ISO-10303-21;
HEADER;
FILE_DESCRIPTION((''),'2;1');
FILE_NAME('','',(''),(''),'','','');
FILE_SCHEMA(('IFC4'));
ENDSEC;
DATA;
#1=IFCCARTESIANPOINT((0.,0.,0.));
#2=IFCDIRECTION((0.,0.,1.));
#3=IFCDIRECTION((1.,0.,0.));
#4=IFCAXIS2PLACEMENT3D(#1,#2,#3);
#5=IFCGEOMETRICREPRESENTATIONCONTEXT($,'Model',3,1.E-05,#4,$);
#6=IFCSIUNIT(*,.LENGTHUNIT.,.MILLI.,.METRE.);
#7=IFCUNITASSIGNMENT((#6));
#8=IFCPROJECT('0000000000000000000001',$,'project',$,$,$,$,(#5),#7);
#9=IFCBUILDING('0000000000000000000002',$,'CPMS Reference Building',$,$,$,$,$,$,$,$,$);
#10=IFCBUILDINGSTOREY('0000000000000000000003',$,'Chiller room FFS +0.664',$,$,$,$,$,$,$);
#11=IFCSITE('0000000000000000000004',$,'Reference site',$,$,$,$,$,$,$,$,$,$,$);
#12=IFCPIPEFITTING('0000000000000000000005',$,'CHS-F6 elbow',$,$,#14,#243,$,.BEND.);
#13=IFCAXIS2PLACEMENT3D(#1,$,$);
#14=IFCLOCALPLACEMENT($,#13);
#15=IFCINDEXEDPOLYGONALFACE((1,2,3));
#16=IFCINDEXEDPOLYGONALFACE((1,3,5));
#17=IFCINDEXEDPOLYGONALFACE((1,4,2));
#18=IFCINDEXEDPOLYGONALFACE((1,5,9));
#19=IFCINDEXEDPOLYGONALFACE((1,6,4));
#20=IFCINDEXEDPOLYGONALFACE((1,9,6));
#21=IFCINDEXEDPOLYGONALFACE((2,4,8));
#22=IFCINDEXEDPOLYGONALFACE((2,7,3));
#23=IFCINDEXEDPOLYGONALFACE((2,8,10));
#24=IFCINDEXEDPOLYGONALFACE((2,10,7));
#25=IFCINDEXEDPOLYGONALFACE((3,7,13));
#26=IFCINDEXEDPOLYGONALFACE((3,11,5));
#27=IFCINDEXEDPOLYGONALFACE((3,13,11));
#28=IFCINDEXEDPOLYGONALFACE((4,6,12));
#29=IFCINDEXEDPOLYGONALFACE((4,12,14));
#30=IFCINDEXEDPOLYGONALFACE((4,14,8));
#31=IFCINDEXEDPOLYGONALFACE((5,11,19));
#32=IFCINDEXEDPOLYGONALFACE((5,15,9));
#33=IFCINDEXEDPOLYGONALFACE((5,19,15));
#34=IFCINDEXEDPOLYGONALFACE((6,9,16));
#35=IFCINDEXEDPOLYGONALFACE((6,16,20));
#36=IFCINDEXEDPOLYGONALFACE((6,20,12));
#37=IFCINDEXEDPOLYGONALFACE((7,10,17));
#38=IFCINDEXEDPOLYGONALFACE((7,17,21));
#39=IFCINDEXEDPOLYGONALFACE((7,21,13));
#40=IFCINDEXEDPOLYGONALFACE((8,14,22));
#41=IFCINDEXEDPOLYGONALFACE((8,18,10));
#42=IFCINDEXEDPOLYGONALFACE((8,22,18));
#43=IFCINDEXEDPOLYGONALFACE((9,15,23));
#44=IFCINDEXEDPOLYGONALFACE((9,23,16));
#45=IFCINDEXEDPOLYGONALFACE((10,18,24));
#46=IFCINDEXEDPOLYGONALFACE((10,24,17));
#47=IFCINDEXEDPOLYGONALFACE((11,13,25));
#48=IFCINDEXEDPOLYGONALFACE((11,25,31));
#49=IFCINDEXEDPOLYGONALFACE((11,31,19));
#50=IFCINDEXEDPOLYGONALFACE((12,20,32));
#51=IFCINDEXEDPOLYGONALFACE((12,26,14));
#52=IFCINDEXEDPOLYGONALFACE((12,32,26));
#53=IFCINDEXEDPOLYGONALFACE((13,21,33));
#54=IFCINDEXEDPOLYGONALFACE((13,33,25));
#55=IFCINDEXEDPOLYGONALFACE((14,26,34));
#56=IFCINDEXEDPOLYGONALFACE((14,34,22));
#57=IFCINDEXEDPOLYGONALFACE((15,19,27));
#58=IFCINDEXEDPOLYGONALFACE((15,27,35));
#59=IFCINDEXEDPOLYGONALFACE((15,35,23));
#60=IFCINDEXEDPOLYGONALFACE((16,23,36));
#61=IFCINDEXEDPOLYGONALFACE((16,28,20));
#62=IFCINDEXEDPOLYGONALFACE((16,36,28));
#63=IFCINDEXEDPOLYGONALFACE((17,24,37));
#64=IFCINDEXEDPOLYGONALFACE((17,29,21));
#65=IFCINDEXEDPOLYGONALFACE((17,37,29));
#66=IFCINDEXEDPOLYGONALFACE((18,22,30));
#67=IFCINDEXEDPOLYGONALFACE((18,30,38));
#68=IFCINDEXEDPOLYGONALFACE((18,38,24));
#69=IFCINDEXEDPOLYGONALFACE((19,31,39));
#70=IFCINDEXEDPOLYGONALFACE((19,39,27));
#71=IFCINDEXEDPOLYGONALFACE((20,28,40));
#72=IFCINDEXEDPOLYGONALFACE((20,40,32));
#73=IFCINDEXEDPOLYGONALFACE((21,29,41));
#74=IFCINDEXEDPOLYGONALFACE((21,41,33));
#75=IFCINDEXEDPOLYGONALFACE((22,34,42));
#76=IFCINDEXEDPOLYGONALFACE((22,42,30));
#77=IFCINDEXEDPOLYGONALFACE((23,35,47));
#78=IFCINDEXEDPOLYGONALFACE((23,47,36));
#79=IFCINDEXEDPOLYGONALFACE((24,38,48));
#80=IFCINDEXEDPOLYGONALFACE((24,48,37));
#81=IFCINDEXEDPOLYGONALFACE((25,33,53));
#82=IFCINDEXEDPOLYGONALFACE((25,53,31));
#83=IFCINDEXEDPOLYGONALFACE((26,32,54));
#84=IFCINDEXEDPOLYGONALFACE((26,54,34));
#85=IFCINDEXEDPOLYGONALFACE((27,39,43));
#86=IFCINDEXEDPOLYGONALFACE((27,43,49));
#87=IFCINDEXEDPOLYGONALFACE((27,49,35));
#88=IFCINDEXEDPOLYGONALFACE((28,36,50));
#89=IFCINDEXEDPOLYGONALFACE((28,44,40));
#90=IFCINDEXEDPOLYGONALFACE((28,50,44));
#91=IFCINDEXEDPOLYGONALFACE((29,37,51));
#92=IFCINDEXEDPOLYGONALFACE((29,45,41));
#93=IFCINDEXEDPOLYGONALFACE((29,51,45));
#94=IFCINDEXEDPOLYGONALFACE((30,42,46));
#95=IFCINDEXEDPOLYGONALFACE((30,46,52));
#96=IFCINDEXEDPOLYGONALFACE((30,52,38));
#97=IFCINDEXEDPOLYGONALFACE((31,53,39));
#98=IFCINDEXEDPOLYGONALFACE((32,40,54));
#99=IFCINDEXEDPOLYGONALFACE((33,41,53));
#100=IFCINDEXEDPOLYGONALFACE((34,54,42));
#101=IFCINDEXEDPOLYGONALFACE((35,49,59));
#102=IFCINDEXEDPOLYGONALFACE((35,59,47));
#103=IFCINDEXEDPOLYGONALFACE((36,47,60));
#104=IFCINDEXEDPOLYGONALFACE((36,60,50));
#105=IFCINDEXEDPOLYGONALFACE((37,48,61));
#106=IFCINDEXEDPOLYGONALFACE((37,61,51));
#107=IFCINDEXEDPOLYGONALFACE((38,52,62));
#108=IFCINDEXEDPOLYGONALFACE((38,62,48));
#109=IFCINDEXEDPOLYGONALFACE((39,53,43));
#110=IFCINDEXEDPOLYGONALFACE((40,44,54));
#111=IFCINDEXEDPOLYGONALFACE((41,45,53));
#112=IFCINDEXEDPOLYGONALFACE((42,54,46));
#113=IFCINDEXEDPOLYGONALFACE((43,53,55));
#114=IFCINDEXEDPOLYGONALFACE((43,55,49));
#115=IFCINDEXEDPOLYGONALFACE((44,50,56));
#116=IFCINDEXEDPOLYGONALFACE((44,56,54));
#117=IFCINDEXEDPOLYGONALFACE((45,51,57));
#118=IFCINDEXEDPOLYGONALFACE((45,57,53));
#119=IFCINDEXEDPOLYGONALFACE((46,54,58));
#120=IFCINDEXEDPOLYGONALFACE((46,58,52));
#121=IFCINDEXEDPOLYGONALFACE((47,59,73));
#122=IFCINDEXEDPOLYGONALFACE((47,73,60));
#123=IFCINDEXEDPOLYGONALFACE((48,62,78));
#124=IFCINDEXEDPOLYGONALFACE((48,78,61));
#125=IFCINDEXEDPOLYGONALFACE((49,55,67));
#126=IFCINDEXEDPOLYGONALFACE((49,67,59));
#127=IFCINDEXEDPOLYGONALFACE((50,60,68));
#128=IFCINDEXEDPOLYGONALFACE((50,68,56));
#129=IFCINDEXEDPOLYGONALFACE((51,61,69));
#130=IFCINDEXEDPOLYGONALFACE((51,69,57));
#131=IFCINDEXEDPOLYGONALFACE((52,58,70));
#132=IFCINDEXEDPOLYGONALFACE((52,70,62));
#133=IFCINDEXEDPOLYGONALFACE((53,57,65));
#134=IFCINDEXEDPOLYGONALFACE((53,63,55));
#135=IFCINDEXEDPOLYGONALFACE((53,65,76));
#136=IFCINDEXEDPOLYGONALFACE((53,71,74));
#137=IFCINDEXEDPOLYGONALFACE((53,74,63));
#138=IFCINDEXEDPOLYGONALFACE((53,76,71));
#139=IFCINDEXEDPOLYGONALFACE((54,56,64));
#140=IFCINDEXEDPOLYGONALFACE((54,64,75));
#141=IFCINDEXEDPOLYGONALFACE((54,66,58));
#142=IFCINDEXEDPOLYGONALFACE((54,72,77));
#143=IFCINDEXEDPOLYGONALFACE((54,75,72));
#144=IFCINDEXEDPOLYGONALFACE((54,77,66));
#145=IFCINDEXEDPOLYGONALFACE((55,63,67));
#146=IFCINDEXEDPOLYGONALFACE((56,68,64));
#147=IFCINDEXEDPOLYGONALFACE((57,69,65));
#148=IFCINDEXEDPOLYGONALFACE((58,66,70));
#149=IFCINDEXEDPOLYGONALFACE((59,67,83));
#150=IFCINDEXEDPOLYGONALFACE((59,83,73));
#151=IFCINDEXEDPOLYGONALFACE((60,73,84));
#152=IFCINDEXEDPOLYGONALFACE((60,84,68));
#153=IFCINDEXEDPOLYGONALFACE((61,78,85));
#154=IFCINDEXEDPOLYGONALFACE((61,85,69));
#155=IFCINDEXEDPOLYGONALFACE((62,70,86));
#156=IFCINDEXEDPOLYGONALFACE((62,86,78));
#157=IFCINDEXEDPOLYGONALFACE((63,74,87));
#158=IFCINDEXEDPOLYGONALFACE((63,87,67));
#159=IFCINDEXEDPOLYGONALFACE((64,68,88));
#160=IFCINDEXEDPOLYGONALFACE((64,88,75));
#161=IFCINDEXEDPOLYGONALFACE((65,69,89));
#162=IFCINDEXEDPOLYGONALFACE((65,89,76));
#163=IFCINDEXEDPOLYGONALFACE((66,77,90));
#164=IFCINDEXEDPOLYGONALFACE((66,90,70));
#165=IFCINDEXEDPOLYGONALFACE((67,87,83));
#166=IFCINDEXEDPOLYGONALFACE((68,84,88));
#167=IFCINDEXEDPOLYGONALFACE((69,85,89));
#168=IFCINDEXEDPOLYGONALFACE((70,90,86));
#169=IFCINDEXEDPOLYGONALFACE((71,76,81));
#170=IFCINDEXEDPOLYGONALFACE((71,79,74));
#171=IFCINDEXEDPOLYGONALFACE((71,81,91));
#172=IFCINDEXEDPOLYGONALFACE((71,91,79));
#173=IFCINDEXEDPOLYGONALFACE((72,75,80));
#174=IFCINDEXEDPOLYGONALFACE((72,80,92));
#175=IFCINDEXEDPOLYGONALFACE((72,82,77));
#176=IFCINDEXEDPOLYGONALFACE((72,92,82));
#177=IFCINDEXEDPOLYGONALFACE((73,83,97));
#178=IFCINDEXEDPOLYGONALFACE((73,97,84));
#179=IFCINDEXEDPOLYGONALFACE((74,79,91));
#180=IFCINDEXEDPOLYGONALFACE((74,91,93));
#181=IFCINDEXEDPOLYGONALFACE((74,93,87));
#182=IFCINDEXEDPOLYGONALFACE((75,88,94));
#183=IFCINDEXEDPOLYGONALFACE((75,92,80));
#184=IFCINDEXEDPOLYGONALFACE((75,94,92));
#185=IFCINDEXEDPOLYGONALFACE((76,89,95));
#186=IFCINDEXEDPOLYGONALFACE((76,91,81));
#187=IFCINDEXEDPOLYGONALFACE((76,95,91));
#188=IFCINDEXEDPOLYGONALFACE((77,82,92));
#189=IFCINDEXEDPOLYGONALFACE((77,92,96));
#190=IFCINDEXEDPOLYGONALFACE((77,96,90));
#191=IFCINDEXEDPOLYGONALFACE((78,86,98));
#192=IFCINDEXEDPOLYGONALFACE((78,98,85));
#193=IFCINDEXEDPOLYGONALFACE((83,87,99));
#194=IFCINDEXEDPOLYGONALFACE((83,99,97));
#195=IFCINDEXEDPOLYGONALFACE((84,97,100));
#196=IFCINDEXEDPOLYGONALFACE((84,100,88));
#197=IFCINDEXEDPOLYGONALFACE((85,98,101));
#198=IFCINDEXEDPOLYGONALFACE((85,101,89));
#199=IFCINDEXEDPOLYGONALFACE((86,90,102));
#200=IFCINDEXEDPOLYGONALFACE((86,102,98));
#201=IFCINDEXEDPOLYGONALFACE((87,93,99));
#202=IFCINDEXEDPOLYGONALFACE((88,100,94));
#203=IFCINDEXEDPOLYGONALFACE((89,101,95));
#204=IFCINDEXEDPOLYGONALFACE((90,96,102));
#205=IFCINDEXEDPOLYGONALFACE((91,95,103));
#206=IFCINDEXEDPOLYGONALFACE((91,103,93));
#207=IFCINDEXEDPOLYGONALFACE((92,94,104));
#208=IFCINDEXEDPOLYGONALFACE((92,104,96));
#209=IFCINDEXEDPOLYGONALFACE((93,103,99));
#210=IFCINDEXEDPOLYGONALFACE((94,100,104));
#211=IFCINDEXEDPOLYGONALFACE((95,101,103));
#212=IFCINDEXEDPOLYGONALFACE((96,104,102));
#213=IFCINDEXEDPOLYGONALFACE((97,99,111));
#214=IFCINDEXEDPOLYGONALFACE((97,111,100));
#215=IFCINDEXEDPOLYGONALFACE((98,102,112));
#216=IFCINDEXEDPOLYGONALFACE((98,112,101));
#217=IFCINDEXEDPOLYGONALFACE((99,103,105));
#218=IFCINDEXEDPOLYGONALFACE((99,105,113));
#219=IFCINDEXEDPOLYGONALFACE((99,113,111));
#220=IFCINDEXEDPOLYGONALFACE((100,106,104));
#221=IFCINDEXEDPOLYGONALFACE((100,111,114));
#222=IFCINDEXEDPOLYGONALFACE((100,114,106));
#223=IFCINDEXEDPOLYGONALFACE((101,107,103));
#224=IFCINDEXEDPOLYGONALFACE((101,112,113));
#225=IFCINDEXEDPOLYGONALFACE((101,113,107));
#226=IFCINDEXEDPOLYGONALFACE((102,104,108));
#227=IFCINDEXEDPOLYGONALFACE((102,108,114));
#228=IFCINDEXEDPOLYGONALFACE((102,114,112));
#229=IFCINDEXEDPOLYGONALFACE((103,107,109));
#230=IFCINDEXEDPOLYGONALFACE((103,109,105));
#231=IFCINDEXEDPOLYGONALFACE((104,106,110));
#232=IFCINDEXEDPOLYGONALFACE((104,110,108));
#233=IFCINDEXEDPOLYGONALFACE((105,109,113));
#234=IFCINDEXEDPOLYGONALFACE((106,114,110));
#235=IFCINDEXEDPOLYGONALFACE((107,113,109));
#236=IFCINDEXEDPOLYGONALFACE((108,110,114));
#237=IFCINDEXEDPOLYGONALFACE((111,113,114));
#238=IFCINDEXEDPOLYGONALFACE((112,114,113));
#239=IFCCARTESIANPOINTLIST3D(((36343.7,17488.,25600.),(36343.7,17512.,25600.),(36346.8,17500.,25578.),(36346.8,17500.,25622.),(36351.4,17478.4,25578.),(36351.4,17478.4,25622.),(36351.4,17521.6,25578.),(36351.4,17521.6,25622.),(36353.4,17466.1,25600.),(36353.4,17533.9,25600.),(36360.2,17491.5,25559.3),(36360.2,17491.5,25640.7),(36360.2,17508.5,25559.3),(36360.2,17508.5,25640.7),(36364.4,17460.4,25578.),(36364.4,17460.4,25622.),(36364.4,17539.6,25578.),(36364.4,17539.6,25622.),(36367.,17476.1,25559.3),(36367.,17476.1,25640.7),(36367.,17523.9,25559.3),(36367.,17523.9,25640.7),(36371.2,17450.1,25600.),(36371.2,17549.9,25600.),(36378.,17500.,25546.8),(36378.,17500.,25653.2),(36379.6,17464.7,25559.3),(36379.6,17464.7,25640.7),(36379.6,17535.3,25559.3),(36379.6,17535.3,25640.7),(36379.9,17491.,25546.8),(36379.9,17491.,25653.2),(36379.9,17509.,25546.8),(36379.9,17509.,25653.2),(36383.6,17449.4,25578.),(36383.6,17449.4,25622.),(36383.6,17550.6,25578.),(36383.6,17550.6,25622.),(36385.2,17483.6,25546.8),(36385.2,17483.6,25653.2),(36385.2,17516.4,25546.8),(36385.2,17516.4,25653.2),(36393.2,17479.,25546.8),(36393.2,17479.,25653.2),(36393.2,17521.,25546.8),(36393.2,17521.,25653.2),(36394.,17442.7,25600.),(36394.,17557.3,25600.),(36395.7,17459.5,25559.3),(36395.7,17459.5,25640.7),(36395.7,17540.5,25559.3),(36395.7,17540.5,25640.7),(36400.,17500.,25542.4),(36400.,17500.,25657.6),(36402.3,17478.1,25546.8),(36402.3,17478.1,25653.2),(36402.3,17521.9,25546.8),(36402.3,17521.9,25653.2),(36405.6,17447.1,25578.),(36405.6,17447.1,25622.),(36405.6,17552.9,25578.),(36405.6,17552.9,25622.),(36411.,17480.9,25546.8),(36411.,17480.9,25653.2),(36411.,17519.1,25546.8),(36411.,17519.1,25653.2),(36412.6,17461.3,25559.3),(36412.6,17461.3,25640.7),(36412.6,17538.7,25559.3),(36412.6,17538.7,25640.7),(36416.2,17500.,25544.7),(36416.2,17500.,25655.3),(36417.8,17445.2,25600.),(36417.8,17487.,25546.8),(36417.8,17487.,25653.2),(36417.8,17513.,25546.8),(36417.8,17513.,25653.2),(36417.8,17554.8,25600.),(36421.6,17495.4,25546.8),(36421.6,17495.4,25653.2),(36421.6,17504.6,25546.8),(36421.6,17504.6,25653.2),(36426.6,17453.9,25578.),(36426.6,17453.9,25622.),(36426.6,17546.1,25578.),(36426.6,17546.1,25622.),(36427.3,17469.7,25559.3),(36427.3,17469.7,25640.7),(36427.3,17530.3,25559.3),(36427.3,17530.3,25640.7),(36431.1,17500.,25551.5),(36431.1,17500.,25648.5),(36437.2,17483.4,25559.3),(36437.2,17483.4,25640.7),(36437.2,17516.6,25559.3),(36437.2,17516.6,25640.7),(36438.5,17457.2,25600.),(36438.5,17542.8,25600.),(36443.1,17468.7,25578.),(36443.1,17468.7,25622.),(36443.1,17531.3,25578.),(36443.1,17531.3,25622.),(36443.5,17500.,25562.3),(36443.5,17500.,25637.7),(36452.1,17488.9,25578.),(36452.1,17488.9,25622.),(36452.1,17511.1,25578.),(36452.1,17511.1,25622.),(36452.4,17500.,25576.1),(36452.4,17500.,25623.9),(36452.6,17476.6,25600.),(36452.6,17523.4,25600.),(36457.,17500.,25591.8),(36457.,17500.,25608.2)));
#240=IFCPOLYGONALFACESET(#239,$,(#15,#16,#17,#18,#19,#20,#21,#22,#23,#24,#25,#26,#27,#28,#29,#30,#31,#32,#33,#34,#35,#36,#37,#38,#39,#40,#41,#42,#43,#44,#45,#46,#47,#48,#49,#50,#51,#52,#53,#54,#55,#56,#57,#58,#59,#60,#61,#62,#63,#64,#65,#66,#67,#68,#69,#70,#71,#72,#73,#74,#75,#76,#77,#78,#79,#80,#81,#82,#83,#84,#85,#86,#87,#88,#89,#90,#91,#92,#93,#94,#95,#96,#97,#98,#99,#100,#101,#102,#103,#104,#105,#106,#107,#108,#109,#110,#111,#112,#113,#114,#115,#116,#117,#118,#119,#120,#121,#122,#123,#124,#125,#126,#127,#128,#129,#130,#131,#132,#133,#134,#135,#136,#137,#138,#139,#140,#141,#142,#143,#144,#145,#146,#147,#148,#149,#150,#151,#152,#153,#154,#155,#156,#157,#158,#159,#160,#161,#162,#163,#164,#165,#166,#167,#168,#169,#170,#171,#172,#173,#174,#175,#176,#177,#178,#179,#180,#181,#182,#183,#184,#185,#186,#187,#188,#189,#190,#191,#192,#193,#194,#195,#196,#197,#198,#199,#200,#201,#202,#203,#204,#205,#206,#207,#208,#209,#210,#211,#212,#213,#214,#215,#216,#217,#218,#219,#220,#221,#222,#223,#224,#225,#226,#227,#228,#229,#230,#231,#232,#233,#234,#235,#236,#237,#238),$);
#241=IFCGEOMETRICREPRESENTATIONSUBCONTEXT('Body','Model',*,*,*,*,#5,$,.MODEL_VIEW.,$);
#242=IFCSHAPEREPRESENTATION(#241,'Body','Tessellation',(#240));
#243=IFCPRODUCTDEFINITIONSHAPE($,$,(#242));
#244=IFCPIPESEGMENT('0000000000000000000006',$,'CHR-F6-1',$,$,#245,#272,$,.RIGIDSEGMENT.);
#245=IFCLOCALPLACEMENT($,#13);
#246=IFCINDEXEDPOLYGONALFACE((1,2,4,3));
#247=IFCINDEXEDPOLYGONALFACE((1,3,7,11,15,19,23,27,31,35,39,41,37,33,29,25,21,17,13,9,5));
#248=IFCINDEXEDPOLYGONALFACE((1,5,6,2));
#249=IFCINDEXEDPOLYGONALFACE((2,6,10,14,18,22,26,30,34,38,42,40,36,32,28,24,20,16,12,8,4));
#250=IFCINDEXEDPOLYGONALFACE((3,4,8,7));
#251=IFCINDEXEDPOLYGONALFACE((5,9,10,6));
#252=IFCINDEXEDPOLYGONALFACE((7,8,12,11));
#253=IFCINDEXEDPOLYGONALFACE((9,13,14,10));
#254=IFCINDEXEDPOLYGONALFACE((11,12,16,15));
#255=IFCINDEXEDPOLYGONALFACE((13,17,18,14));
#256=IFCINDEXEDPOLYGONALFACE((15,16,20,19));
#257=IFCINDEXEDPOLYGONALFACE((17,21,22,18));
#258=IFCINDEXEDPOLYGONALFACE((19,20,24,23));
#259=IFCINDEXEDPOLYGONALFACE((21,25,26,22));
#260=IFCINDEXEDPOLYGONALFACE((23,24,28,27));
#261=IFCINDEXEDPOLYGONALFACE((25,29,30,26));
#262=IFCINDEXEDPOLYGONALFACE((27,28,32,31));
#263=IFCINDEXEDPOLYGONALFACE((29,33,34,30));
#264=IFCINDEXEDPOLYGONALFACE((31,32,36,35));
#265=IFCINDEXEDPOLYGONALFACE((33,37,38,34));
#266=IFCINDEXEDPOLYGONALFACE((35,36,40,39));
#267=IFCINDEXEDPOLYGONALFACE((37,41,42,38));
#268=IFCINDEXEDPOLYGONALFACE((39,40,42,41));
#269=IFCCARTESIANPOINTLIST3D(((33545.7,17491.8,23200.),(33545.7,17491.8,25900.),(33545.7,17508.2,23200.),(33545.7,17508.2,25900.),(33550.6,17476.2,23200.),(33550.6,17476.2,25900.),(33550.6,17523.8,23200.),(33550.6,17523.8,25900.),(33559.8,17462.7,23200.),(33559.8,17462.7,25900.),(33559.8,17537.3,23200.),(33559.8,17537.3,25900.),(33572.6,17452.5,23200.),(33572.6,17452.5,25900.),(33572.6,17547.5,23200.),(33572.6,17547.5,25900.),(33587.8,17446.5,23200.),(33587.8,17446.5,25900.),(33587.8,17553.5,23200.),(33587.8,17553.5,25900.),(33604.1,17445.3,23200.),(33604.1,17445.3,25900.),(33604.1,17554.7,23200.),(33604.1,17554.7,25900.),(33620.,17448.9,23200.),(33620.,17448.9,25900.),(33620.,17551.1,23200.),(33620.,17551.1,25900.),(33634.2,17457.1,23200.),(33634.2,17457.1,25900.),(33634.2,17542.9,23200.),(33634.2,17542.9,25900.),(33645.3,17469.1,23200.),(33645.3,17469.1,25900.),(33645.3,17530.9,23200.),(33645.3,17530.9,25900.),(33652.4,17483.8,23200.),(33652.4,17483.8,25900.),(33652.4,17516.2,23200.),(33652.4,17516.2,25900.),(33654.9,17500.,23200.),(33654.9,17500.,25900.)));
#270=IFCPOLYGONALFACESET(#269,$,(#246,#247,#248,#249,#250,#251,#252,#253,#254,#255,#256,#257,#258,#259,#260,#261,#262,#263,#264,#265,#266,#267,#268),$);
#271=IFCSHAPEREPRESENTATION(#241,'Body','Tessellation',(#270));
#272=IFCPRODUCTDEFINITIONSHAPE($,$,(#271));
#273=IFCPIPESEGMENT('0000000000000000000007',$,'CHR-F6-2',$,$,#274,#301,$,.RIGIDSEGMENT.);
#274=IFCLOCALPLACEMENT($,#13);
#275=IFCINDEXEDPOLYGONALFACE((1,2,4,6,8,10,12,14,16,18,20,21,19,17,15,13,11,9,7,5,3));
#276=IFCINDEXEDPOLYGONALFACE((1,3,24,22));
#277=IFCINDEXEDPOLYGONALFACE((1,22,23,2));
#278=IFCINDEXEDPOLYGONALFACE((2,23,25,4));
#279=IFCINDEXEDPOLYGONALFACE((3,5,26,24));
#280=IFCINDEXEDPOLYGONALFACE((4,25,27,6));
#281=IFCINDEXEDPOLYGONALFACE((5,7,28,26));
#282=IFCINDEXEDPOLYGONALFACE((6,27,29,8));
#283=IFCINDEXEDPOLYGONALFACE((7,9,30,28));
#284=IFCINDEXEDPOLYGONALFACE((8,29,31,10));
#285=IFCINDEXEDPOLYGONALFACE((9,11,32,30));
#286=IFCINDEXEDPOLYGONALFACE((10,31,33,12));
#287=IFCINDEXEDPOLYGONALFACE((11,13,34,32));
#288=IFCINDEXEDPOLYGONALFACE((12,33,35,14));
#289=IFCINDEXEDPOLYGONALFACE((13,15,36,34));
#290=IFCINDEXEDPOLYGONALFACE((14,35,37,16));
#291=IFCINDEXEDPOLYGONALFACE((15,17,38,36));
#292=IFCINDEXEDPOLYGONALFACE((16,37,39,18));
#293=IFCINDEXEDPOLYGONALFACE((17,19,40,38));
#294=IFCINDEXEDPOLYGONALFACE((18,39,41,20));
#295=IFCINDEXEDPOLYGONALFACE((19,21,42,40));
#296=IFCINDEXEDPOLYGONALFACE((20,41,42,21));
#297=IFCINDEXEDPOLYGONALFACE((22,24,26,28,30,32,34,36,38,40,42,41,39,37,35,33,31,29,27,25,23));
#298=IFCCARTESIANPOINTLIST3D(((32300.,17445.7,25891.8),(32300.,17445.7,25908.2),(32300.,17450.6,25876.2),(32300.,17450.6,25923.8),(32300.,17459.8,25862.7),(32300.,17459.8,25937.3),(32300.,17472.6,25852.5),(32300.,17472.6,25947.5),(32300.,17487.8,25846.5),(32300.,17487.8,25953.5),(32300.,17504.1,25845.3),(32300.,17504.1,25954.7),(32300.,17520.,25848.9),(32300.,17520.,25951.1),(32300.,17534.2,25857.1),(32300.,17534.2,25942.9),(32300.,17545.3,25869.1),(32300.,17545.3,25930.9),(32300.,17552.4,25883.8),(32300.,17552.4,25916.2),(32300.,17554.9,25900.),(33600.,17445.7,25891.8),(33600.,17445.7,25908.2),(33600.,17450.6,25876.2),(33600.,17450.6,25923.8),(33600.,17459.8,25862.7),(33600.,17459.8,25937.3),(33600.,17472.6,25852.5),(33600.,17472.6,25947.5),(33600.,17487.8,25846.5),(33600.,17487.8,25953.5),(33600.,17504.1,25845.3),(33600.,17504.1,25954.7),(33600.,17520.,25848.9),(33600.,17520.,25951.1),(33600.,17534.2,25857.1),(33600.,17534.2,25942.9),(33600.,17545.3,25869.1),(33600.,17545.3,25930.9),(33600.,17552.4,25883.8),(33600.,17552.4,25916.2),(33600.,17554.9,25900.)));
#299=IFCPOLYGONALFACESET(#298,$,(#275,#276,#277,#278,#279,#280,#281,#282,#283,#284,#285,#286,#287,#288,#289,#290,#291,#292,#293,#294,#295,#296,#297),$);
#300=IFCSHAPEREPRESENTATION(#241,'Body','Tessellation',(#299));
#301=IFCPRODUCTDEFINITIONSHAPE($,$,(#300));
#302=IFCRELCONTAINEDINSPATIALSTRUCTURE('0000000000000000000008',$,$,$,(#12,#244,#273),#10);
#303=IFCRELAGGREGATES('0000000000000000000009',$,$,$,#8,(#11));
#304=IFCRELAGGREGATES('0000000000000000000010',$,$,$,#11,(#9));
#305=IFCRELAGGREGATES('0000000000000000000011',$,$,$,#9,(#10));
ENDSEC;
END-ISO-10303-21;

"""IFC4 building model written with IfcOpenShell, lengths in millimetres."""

from ifc_helpers import new_model, entity, si_unit, frame, origin_with_axes, origin_2d, place, context, subcontext, project, spatial, circle_curve, outline, extrude, element, save


model = new_model("IFC4")

# Units and contexts
model_context = context("Model", 3, precision=1e-05, world=origin_with_axes())
body_context = subcontext(model_context, "Body", "Model", "MODEL_VIEW")
ifc_project = project(units=[si_unit("LENGTHUNIT", "METRE", prefix="MILLI")], contexts=[model_context])

# Site, building, storey
site = spatial("IfcSite", under=ifc_project, Name="Reference site")
building = spatial("IfcBuilding", under=site, Name="CPMS Reference Building")
storey = spatial("IfcBuildingStorey", under=building, Name="Chiller room FFS +0.664")

# Pipe fitting
pipe_fitting_1_placement = place(None, origin_with_axes())
element("IfcPipeFitting", 1, at=pipe_fitting_1_placement, inside=storey, Name="CHS-F6 elbow", PredefinedType="BEND", context=body_context, shape_type="CSG", body=[
    entity("IfcSphere", entity("IfcAxis2Placement3D", entity("IfcCartesianPoint", [36400.0, 17500.0, 25600.0]), entity("IfcDirection", [0.0, 0.0, 1.0]), entity("IfcDirection", [1.0, 0.0, 0.0])), 57.6),
])

# Pipe segments
pipe_segment_1_placement = place(None, origin_with_axes())
element("IfcPipeSegment", 2, at=pipe_segment_1_placement, inside=storey, Name="CHR-F6-1", PredefinedType="RIGIDSEGMENT", context=body_context, shape_type="SweptSolid", body=[
    extrude(outline(circle_curve(origin_2d(), 54.9)), frame((33600.0, 17500.0, 23200.0), z_axis=(0.0, 0.0, 1.0), x_axis=(1.0, 0.0, 0.0)), (0.0, 0.0, 1.0), 2700.0),
])
pipe_segment_2_placement = place(None, origin_with_axes())
element("IfcPipeSegment", 3, at=pipe_segment_2_placement, inside=storey, Name="CHR-F6-2", PredefinedType="RIGIDSEGMENT", context=body_context, shape_type="SweptSolid", body=[
    extrude(outline(circle_curve(origin_2d(), 54.9)), frame((33600.0, 17500.0, 25900.0), z_axis=(-1.0, 0.0, 0.0), x_axis=(0.0, 1.0, 0.0)), (0.0, 0.0, 1.0), 1300.0),
])

save(model, "model.ifc")
